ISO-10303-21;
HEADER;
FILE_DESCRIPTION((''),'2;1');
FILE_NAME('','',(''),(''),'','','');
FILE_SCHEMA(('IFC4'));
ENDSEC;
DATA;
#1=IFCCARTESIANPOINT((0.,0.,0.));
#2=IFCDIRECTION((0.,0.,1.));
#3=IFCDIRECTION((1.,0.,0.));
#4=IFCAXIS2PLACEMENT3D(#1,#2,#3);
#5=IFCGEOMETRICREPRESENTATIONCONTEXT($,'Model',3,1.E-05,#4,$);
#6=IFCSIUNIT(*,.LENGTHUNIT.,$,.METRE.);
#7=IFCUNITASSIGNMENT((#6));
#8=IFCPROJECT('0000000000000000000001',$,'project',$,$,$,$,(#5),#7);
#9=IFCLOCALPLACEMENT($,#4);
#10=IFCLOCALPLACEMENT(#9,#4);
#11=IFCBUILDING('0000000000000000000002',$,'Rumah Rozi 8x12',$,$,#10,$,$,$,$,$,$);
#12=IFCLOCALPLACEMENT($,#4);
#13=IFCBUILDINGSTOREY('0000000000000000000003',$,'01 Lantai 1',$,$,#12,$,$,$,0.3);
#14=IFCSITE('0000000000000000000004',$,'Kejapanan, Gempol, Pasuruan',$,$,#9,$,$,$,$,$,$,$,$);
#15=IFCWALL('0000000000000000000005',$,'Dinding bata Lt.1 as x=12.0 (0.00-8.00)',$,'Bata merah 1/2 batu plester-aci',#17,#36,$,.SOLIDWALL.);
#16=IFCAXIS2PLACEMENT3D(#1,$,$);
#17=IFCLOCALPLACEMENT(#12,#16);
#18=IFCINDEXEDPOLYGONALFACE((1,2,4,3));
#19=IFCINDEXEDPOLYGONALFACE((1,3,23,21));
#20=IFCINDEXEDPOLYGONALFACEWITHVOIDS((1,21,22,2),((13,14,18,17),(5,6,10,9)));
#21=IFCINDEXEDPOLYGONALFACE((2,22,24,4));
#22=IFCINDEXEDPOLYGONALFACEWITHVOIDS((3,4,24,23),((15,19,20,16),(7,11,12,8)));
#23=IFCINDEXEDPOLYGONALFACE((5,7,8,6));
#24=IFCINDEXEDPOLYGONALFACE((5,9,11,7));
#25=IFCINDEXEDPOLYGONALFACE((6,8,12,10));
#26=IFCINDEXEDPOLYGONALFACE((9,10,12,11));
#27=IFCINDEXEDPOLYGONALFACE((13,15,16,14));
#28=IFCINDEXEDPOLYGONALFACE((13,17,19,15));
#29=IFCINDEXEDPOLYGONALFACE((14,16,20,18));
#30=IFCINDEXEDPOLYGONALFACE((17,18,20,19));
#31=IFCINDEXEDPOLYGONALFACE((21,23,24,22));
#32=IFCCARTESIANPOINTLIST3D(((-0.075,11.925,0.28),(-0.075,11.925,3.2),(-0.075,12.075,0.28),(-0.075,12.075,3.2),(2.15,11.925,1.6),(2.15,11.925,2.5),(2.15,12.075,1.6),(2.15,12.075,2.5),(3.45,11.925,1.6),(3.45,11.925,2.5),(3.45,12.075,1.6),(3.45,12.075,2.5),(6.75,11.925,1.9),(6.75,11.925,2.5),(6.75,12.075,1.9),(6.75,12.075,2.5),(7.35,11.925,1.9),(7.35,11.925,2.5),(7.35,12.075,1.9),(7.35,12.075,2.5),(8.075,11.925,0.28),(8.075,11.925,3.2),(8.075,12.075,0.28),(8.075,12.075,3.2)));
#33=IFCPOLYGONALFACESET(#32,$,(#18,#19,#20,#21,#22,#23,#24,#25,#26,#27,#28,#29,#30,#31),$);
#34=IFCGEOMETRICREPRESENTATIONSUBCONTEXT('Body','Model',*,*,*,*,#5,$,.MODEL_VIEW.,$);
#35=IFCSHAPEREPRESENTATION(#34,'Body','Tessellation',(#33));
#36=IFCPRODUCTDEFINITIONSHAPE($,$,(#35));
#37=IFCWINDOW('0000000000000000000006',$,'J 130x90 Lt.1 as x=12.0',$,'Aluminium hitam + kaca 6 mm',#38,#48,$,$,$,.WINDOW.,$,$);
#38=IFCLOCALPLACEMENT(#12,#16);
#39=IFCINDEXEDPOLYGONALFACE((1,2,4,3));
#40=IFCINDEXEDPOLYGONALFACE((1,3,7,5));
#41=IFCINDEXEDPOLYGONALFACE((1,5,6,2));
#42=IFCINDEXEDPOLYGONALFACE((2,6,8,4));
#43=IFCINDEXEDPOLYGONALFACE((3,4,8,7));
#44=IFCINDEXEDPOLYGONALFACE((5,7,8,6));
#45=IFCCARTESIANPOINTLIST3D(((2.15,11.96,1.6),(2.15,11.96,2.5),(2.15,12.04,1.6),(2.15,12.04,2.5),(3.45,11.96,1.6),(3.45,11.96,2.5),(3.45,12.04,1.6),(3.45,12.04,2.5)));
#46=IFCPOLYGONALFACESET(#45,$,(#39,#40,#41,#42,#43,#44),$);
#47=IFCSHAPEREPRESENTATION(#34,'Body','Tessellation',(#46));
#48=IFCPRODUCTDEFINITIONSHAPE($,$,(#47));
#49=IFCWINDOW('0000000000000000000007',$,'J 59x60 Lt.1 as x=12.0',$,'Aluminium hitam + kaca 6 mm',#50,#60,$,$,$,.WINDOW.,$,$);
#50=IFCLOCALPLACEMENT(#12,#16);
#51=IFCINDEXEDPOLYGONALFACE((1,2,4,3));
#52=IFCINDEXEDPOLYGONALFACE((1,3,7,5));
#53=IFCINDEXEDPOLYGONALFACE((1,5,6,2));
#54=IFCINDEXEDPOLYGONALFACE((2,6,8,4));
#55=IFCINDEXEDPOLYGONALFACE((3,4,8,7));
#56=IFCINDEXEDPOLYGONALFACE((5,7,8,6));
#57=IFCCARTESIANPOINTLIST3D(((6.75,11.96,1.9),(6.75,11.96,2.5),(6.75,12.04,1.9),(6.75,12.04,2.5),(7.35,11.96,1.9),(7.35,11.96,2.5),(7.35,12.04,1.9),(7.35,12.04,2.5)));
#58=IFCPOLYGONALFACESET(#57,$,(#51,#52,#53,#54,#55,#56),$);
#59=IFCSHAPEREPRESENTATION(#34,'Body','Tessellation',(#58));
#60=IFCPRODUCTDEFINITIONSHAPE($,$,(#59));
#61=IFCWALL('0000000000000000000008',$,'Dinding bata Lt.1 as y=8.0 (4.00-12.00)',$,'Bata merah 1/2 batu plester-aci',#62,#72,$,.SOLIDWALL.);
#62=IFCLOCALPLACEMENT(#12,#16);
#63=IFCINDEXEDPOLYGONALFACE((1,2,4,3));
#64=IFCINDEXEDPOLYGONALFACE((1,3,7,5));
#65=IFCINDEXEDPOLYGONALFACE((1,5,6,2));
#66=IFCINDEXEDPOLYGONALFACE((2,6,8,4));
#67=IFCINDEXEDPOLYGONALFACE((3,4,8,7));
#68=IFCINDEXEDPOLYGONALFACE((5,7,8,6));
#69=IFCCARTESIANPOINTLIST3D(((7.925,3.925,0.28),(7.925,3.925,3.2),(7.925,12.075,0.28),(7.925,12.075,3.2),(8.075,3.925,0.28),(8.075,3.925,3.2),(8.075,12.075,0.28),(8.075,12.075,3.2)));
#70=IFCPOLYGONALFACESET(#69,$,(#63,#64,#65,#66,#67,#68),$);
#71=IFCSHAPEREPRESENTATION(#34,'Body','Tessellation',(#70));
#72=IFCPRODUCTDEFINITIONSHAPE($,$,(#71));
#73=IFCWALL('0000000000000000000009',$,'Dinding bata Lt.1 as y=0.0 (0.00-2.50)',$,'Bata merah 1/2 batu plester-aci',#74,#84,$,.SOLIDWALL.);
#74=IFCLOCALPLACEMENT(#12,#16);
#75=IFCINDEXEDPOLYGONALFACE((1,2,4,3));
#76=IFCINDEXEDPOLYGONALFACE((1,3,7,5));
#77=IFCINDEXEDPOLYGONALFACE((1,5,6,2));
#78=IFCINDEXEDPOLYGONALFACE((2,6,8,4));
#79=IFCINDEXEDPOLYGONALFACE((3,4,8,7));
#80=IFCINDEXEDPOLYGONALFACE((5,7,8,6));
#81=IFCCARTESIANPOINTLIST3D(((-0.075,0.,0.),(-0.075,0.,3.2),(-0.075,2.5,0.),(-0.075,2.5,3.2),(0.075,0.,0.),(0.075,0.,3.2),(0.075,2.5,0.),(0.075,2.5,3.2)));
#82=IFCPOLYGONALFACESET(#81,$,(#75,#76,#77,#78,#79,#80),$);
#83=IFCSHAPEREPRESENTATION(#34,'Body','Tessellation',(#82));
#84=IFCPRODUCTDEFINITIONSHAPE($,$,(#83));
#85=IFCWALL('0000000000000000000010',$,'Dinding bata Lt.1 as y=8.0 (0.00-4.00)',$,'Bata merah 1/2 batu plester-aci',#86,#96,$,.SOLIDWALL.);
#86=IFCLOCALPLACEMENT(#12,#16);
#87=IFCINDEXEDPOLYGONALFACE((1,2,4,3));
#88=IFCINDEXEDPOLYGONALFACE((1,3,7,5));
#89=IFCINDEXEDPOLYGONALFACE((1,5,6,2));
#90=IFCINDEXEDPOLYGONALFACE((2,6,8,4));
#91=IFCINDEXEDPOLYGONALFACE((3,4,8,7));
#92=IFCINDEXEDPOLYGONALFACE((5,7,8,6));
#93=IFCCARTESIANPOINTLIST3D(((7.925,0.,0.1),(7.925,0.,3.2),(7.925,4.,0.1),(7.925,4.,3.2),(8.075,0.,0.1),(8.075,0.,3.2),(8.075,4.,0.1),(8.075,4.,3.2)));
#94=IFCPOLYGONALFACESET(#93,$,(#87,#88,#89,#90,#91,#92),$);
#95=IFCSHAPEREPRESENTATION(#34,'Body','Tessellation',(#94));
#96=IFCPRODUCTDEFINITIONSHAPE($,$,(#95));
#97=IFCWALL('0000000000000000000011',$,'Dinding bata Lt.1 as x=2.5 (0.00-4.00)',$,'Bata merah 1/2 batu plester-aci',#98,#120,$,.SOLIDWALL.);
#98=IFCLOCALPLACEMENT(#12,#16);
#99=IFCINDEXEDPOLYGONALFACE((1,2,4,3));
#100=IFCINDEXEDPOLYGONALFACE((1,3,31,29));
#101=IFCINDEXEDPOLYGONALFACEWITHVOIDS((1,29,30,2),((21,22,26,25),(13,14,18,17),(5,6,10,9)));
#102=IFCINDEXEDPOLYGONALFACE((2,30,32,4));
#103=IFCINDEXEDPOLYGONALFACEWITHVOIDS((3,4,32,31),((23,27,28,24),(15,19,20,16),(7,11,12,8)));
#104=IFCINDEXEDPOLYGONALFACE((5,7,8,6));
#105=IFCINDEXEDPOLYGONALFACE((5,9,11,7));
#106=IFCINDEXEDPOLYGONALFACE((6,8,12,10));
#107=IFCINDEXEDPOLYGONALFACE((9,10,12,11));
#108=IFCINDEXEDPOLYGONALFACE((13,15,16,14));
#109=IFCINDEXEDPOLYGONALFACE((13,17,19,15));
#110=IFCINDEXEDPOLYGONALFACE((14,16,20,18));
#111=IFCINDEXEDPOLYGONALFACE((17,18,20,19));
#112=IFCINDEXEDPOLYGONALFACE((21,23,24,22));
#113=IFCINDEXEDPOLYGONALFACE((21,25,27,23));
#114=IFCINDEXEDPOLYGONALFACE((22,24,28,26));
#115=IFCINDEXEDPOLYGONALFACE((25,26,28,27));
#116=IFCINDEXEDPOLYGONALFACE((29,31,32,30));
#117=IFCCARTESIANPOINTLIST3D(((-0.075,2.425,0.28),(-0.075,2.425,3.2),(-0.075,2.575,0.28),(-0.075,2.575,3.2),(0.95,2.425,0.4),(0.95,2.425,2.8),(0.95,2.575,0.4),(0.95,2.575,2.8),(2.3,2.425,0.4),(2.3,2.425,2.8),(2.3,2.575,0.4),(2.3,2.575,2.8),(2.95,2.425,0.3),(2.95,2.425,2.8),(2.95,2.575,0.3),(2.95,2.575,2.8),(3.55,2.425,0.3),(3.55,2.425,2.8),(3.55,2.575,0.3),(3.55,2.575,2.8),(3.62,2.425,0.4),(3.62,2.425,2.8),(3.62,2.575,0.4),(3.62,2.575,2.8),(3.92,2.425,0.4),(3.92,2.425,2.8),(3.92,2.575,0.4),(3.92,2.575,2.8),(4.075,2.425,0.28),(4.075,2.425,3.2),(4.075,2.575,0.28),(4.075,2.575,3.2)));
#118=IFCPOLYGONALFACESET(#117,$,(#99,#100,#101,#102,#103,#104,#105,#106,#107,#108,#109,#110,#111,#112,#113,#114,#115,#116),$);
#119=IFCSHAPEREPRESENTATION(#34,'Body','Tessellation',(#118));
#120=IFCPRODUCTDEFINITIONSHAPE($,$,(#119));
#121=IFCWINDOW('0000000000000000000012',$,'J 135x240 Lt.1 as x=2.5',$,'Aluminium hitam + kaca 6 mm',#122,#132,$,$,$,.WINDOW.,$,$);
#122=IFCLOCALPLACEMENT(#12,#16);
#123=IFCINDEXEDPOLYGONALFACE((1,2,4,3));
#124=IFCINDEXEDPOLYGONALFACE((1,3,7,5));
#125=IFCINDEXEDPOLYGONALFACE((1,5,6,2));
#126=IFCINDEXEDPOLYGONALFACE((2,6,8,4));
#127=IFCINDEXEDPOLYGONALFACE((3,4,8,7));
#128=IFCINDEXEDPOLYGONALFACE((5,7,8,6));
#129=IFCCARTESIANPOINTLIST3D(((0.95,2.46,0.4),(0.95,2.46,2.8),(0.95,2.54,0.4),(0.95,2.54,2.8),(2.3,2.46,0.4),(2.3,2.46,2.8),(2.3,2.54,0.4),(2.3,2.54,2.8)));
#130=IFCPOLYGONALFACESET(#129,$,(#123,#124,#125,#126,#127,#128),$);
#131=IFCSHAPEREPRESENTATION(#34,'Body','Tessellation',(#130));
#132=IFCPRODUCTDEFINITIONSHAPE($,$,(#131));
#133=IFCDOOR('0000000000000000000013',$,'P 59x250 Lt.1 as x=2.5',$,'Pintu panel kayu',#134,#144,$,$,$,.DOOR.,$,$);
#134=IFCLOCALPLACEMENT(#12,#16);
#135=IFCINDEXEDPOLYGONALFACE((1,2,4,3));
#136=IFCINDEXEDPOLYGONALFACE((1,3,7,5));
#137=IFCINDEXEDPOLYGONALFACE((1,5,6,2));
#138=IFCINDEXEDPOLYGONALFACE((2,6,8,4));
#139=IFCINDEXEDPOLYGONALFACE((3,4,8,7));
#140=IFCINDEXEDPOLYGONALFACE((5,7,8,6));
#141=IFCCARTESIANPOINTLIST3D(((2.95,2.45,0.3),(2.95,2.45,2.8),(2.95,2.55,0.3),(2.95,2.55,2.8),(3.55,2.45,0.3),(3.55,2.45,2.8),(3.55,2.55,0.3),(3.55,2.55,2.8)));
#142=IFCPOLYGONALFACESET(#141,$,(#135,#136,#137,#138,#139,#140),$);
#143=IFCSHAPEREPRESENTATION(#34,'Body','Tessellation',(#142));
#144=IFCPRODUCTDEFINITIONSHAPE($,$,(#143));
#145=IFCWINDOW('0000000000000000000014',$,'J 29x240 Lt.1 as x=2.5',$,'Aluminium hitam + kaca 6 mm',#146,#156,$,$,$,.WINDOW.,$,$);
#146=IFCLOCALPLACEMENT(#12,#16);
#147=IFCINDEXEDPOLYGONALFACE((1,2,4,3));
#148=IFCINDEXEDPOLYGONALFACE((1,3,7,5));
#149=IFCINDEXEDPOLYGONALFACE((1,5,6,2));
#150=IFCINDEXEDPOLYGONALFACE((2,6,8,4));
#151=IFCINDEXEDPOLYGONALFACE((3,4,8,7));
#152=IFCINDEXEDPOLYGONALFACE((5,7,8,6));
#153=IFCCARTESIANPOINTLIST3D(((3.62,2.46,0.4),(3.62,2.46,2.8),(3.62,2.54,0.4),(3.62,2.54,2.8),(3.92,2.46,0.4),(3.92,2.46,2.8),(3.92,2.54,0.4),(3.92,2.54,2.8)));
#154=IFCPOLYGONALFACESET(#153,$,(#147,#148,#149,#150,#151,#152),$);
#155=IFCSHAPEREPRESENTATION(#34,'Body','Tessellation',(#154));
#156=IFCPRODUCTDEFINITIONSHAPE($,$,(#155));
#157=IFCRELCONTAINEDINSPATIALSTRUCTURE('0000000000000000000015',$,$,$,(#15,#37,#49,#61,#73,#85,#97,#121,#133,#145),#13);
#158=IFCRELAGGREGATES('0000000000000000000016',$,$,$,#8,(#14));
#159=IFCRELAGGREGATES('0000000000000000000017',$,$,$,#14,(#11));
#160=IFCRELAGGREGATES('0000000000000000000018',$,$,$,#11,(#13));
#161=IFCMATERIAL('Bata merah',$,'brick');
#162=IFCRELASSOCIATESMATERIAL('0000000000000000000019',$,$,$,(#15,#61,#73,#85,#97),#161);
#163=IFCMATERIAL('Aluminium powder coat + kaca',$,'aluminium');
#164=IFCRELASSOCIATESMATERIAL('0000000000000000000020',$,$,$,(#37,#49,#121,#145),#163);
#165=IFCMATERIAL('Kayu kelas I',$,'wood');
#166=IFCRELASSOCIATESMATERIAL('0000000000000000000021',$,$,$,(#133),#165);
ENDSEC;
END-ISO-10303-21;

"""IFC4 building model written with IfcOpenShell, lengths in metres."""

from ifc_helpers import new_model, si_unit, frame, origin_with_axes, place, context, subcontext, project, spatial, line, indexed_curve, outline, extrude, material, element, fill, save


model = new_model("IFC4")

# Units and contexts
model_context = context("Model", 3, precision=1e-05, world=origin_with_axes())
body_context = subcontext(model_context, "Body", "Model", "MODEL_VIEW")
ifc_project = project(units=[si_unit("LENGTHUNIT", "METRE")], contexts=[model_context])

# Site, building, storey
site_placement = place(None, origin_with_axes())
site = spatial("IfcSite", under=ifc_project, at=site_placement, Name="Kejapanan, Gempol, Pasuruan")
building_placement = place(site_placement, origin_with_axes())
building = spatial("IfcBuilding", under=site, at=building_placement, Name="Rumah Rozi 8x12")
storey_placement = place(None, origin_with_axes())
storey = spatial("IfcBuildingStorey", under=building, at=storey_placement, Name="01 Lantai 1", Elevation=0.3)

# Wall, openings, windows
ifc_material_1 = material(Name="Bata merah", Category="brick")
wall_1_placement = place(storey_placement, origin_with_axes())
wall_1 = element("IfcWall", 1, at=wall_1_placement, inside=storey, material=ifc_material_1, Name="Dinding bata Lt.1 as x=12.0 (0.00-8.00)", ObjectType="Bata merah 1/2 batu plester-aci", PredefinedType="SOLIDWALL", context=body_context, shape_type="SweptSolid", body=[
    extrude(outline(indexed_curve([(-0.075, 11.925), (8.075, 11.925), (8.075, 12.075), (-0.075, 12.075)], segments=[line(1, 2, 3, 4, 1)])), frame((0.0, 0.0, 0.28), z_axis=(0.0, 0.0, 1.0), x_axis=(1.0, 0.0, 0.0)), (0.0, 0.0, 1.0), 2.92),
])
opening_1_placement = place(wall_1_placement, origin_with_axes())
opening_1 = element("IfcOpeningElement", 2, at=opening_1_placement, cuts=wall_1, context=body_context, shape_type="SweptSolid", body=[
    extrude(outline(indexed_curve([(2.15, 11.915), (3.45, 11.915), (3.45, 12.085), (2.15, 12.085)], segments=[line(1, 2, 3, 4, 1)])), frame((0.0, 0.0, 1.6), z_axis=(0.0, 0.0, 1.0), x_axis=(1.0, 0.0, 0.0)), (0.0, 0.0, 1.0), 0.9),
])
opening_2_placement = place(wall_1_placement, origin_with_axes())
opening_2 = element("IfcOpeningElement", 3, at=opening_2_placement, cuts=wall_1, context=body_context, shape_type="SweptSolid", body=[
    extrude(outline(indexed_curve([(6.75, 11.915), (7.35, 11.915), (7.35, 12.085), (6.75, 12.085)], segments=[line(1, 2, 3, 4, 1)])), frame((0.0, 0.0, 1.9), z_axis=(0.0, 0.0, 1.0), x_axis=(1.0, 0.0, 0.0)), (0.0, 0.0, 1.0), 0.6),
])
ifc_material_2 = material(Name="Aluminium powder coat + kaca", Category="aluminium")
window_1_placement = place(storey_placement, origin_with_axes())
window_1 = element("IfcWindow", 4, at=window_1_placement, inside=storey, material=ifc_material_2, Name="J 130x90 Lt.1 as x=12.0", ObjectType="Aluminium hitam + kaca 6 mm", PredefinedType="WINDOW", context=body_context, shape_type="SweptSolid", body=[
    extrude(outline(indexed_curve([(2.15, 11.96), (3.45, 11.96), (3.45, 12.04), (2.15, 12.04)], segments=[line(1, 2, 3, 4, 1)])), frame((0.0, 0.0, 1.6), z_axis=(0.0, 0.0, 1.0), x_axis=(1.0, 0.0, 0.0)), (0.0, 0.0, 1.0), 0.9),
])
fill(opening_1, window_1)
window_2_placement = place(storey_placement, origin_with_axes())
window_2 = element("IfcWindow", 5, at=window_2_placement, inside=storey, material=ifc_material_2, Name="J 59x60 Lt.1 as x=12.0", ObjectType="Aluminium hitam + kaca 6 mm", PredefinedType="WINDOW", context=body_context, shape_type="SweptSolid", body=[
    extrude(outline(indexed_curve([(6.75, 11.96), (7.35, 11.96), (7.35, 12.04), (6.75, 12.04)], segments=[line(1, 2, 3, 4, 1)])), frame((0.0, 0.0, 1.9), z_axis=(0.0, 0.0, 1.0), x_axis=(1.0, 0.0, 0.0)), (0.0, 0.0, 1.0), 0.6),
])
fill(opening_2, window_2)

# Walls
wall_2_placement = place(storey_placement, origin_with_axes())
element("IfcWall", 6, at=wall_2_placement, inside=storey, material=ifc_material_1, Name="Dinding bata Lt.1 as y=8.0 (4.00-12.00)", ObjectType="Bata merah 1/2 batu plester-aci", PredefinedType="SOLIDWALL", context=body_context, shape_type="SweptSolid", body=[
    extrude(outline(indexed_curve([(7.925, 3.925), (8.075, 3.925), (8.075, 12.075), (7.925, 12.075)], segments=[line(1, 2, 3, 4, 1)])), frame((0.0, 0.0, 0.28), z_axis=(0.0, 0.0, 1.0), x_axis=(1.0, 0.0, 0.0)), (0.0, 0.0, 1.0), 2.92),
])
wall_3_placement = place(storey_placement, origin_with_axes())
element("IfcWall", 7, at=wall_3_placement, inside=storey, material=ifc_material_1, Name="Dinding bata Lt.1 as y=0.0 (0.00-2.50)", ObjectType="Bata merah 1/2 batu plester-aci", PredefinedType="SOLIDWALL", context=body_context, shape_type="SweptSolid", body=[
    extrude(outline(indexed_curve([(-0.075, 0.0), (0.075, 0.0), (0.075, 2.5), (-0.075, 2.5)], segments=[line(1, 2, 3, 4, 1)])), origin_with_axes(), (0.0, 0.0, 1.0), 3.2),
])
wall_4_placement = place(storey_placement, origin_with_axes())
element("IfcWall", 8, at=wall_4_placement, inside=storey, material=ifc_material_1, Name="Dinding bata Lt.1 as y=8.0 (0.00-4.00)", ObjectType="Bata merah 1/2 batu plester-aci", PredefinedType="SOLIDWALL", context=body_context, shape_type="SweptSolid", body=[
    extrude(outline(indexed_curve([(7.925, 0.0), (8.075, 0.0), (8.075, 4.0), (7.925, 4.0)], segments=[line(1, 2, 3, 4, 1)])), frame((0.0, 0.0, 0.1), z_axis=(0.0, 0.0, 1.0), x_axis=(1.0, 0.0, 0.0)), (0.0, 0.0, 1.0), 3.1),
])

# Wall, openings, windows, door
wall_5_placement = place(storey_placement, origin_with_axes())
wall_5 = element("IfcWall", 9, at=wall_5_placement, inside=storey, material=ifc_material_1, Name="Dinding bata Lt.1 as x=2.5 (0.00-4.00)", ObjectType="Bata merah 1/2 batu plester-aci", PredefinedType="SOLIDWALL", context=body_context, shape_type="SweptSolid", body=[
    extrude(outline(indexed_curve([(-0.075, 2.425), (4.075, 2.425), (4.075, 2.575), (-0.075, 2.575)], segments=[line(1, 2, 3, 4, 1)])), frame((0.0, 0.0, 0.28), z_axis=(0.0, 0.0, 1.0), x_axis=(1.0, 0.0, 0.0)), (0.0, 0.0, 1.0), 2.92),
])
opening_3_placement = place(wall_5_placement, origin_with_axes())
opening_3 = element("IfcOpeningElement", 10, at=opening_3_placement, cuts=wall_5, context=body_context, shape_type="SweptSolid", body=[
    extrude(outline(indexed_curve([(0.95, 2.415), (2.3, 2.415), (2.3, 2.585), (0.95, 2.585)], segments=[line(1, 2, 3, 4, 1)])), frame((0.0, 0.0, 0.4), z_axis=(0.0, 0.0, 1.0), x_axis=(1.0, 0.0, 0.0)), (0.0, 0.0, 1.0), 2.4),
])
opening_4_placement = place(wall_5_placement, origin_with_axes())
opening_4 = element("IfcOpeningElement", 11, at=opening_4_placement, cuts=wall_5, context=body_context, shape_type="SweptSolid", body=[
    extrude(outline(indexed_curve([(2.95, 2.415), (3.55, 2.415), (3.55, 2.585), (2.95, 2.585)], segments=[line(1, 2, 3, 4, 1)])), frame((0.0, 0.0, 0.3), z_axis=(0.0, 0.0, 1.0), x_axis=(1.0, 0.0, 0.0)), (0.0, 0.0, 1.0), 2.5),
])
opening_5_placement = place(wall_5_placement, origin_with_axes())
opening_5 = element("IfcOpeningElement", 12, at=opening_5_placement, cuts=wall_5, context=body_context, shape_type="SweptSolid", body=[
    extrude(outline(indexed_curve([(3.62, 2.415), (3.92, 2.415), (3.92, 2.585), (3.62, 2.585)], segments=[line(1, 2, 3, 4, 1)])), frame((0.0, 0.0, 0.4), z_axis=(0.0, 0.0, 1.0), x_axis=(1.0, 0.0, 0.0)), (0.0, 0.0, 1.0), 2.4),
])
window_3_placement = place(storey_placement, origin_with_axes())
window_3 = element("IfcWindow", 13, at=window_3_placement, inside=storey, material=ifc_material_2, Name="J 135x240 Lt.1 as x=2.5", ObjectType="Aluminium hitam + kaca 6 mm", PredefinedType="WINDOW", context=body_context, shape_type="SweptSolid", body=[
    extrude(outline(indexed_curve([(0.95, 2.46), (2.3, 2.46), (2.3, 2.54), (0.95, 2.54)], segments=[line(1, 2, 3, 4, 1)])), frame((0.0, 0.0, 0.4), z_axis=(0.0, 0.0, 1.0), x_axis=(1.0, 0.0, 0.0)), (0.0, 0.0, 1.0), 2.4),
])
fill(opening_3, window_3)
ifc_material_3 = material(Name="Kayu kelas I", Category="wood")
door_1_placement = place(storey_placement, origin_with_axes())
door_1 = element("IfcDoor", 14, at=door_1_placement, inside=storey, material=ifc_material_3, Name="P 59x250 Lt.1 as x=2.5", ObjectType="Pintu panel kayu", PredefinedType="DOOR", context=body_context, shape_type="SweptSolid", body=[
    extrude(outline(indexed_curve([(2.95, 2.45), (3.55, 2.45), (3.55, 2.55), (2.95, 2.55)], segments=[line(1, 2, 3, 4, 1)])), frame((0.0, 0.0, 0.3), z_axis=(0.0, 0.0, 1.0), x_axis=(1.0, 0.0, 0.0)), (0.0, 0.0, 1.0), 2.5),
])
fill(opening_4, door_1)
window_4_placement = place(storey_placement, origin_with_axes())
window_4 = element("IfcWindow", 15, at=window_4_placement, inside=storey, material=ifc_material_2, Name="J 29x240 Lt.1 as x=2.5", ObjectType="Aluminium hitam + kaca 6 mm", PredefinedType="WINDOW", context=body_context, shape_type="SweptSolid", body=[
    extrude(outline(indexed_curve([(3.62, 2.46), (3.92, 2.46), (3.92, 2.54), (3.62, 2.54)], segments=[line(1, 2, 3, 4, 1)])), frame((0.0, 0.0, 0.4), z_axis=(0.0, 0.0, 1.0), x_axis=(1.0, 0.0, 0.0)), (0.0, 0.0, 1.0), 2.4),
])
fill(opening_5, window_4)

save(model, "model.ifc")
